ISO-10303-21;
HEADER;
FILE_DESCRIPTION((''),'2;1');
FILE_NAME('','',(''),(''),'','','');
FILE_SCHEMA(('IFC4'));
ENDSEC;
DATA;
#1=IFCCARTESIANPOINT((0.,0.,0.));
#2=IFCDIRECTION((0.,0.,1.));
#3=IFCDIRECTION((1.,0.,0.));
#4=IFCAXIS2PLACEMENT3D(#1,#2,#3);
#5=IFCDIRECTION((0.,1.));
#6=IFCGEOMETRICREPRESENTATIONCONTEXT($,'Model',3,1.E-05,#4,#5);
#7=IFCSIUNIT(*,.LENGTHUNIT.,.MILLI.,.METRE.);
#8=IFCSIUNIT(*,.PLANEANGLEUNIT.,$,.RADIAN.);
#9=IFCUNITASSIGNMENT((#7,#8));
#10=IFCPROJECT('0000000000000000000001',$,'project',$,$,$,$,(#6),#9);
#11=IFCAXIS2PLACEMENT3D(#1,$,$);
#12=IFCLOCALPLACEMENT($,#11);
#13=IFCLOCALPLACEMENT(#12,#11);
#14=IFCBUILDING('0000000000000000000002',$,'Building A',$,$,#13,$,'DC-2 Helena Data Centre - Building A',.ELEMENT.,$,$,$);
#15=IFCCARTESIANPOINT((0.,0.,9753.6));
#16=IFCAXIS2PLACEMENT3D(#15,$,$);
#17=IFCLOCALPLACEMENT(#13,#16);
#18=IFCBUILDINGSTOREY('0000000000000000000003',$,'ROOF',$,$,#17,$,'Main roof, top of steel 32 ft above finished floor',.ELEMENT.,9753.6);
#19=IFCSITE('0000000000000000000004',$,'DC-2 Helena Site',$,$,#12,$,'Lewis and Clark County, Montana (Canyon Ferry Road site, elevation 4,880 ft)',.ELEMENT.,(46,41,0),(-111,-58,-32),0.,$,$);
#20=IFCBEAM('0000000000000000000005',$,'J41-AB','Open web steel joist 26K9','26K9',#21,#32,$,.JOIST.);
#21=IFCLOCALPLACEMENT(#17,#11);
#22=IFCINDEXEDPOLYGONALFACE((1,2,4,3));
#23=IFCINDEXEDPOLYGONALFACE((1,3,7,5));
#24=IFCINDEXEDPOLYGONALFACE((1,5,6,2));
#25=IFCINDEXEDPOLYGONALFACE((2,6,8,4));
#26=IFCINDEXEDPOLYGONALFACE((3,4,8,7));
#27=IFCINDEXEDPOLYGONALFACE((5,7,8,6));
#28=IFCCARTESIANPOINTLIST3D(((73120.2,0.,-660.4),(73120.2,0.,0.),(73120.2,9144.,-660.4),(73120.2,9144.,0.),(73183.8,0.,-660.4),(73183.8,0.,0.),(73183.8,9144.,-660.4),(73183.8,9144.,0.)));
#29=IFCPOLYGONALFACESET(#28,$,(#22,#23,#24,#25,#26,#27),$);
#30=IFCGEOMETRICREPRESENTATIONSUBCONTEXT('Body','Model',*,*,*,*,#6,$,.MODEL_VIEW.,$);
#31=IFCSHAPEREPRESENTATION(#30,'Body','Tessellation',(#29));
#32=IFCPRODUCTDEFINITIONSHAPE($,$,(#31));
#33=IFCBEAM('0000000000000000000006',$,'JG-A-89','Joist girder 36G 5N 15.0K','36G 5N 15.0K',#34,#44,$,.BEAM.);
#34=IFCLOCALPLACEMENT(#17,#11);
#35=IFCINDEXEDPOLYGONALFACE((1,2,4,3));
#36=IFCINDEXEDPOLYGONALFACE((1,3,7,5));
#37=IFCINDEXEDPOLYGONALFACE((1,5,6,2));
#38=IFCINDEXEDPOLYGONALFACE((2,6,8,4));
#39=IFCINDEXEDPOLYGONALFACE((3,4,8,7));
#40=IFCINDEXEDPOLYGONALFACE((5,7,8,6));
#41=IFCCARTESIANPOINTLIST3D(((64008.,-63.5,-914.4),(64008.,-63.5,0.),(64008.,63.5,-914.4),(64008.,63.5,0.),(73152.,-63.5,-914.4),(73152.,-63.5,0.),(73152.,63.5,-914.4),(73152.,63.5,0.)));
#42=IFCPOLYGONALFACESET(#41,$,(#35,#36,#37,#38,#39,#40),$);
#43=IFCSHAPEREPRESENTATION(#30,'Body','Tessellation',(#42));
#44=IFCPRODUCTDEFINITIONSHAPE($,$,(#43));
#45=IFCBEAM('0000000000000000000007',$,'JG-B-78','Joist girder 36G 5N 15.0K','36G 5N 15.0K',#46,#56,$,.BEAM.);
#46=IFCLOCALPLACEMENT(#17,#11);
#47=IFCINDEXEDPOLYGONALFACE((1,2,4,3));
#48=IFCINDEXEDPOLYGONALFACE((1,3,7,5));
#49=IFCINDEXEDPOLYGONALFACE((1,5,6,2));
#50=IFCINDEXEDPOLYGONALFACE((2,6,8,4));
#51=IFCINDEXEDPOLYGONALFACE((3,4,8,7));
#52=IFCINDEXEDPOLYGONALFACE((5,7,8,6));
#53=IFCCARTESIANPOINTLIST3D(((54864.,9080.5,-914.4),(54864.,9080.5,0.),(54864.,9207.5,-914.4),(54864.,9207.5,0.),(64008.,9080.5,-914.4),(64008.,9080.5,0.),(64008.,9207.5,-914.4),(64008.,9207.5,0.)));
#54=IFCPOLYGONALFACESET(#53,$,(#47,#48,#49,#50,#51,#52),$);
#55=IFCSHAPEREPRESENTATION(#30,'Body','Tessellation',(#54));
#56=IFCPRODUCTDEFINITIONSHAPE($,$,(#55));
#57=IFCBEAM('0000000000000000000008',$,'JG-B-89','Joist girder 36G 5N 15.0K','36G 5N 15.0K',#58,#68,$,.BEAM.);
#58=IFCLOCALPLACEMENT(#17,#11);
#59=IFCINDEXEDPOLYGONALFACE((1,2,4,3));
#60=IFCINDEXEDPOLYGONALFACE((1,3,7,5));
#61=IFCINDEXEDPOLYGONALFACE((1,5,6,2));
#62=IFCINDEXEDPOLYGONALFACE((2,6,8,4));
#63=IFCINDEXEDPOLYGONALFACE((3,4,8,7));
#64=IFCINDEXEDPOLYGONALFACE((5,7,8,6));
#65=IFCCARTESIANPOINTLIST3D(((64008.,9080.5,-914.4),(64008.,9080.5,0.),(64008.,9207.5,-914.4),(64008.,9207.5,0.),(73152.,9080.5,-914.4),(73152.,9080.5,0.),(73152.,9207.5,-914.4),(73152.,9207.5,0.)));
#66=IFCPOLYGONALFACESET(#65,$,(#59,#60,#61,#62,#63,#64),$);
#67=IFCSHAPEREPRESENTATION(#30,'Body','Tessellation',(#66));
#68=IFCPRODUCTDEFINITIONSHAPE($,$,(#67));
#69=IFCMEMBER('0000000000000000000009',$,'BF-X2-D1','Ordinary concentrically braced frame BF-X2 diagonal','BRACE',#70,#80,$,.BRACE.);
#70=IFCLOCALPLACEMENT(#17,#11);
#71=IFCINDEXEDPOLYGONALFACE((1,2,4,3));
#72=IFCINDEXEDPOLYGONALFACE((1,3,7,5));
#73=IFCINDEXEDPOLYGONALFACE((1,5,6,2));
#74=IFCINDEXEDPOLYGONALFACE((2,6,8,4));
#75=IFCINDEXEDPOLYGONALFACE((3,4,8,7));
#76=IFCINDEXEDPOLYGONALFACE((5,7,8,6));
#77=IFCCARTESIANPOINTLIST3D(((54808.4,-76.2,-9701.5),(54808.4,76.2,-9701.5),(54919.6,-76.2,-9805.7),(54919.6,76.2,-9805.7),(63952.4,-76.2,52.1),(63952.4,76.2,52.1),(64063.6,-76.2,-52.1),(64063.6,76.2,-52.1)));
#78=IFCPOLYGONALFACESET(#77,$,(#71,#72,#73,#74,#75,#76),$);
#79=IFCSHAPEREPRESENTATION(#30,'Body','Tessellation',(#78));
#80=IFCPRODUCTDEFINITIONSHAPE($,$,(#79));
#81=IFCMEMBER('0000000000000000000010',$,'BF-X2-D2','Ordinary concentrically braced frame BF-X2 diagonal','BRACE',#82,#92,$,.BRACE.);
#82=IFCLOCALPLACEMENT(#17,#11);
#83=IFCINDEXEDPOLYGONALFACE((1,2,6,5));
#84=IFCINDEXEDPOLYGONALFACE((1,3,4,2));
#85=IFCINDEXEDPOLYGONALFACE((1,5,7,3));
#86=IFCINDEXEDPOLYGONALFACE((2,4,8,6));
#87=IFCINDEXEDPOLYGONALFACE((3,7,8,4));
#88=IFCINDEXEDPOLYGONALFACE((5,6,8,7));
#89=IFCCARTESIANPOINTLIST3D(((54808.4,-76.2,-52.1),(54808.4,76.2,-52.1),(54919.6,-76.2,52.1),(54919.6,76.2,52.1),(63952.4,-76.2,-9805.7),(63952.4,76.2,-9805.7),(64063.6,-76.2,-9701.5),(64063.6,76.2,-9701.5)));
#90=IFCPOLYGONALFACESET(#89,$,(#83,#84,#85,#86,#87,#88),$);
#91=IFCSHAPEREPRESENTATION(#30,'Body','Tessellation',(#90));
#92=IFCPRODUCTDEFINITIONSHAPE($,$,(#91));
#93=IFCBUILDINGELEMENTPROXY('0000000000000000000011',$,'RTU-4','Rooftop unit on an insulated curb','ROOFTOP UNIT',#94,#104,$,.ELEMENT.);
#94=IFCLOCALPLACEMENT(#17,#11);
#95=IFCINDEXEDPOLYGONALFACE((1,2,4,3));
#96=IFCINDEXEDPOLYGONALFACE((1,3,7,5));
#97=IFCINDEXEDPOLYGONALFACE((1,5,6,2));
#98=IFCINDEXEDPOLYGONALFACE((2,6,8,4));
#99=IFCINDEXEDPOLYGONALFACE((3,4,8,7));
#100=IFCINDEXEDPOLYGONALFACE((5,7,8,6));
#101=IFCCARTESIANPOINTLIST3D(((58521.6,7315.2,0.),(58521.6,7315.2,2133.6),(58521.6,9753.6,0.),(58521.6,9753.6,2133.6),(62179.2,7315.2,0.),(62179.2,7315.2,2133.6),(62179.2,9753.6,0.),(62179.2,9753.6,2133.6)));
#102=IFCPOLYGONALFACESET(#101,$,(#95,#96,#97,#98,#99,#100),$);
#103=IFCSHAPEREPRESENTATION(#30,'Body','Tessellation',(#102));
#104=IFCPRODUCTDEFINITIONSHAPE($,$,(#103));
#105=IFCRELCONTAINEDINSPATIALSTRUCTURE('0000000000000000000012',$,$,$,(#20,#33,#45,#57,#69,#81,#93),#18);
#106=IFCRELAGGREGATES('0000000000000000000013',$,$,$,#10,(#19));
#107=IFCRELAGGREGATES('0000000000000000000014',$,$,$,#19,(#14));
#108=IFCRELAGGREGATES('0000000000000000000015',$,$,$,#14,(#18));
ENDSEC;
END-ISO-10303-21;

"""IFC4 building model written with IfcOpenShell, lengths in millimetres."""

from ifc_helpers import new_model, si_unit, direction, frame, origin, origin_with_axes, origin_2d, place, context, subcontext, project, spatial, rectangle, extrude, element, save


model = new_model("IFC4")

# Units and contexts
model_context = context("Model", 3, precision=1e-05, world=origin_with_axes(), true_north=direction((0.0, 1.0)))
body_context = subcontext(model_context, "Body", "Model", "MODEL_VIEW")
ifc_project = project(units=[si_unit("LENGTHUNIT", "METRE", prefix="MILLI"), si_unit("PLANEANGLEUNIT", "RADIAN")], contexts=[model_context])

# Site, building, storey
site_placement = place(None, origin())
site = spatial("IfcSite", under=ifc_project, at=site_placement, Name="DC-2 Helena Site", LongName="Lewis and Clark County, Montana (Canyon Ferry Road site, elevation 4,880 ft)", CompositionType="ELEMENT", RefLatitude=(46, 41, 0), RefLongitude=(-111, -58, -32), RefElevation=0.0)
building_placement = place(site_placement, origin())
building = spatial("IfcBuilding", under=site, at=building_placement, Name="Building A", LongName="DC-2 Helena Data Centre - Building A", CompositionType="ELEMENT")
storey_placement = place(building_placement, frame((0.0, 0.0, 9753.6)))
storey = spatial("IfcBuildingStorey", under=building, at=storey_placement, Name="ROOF", LongName="Main roof, top of steel 32 ft above finished floor", CompositionType="ELEMENT", Elevation=9753.6)

# Shared definitions
placement_1 = place(storey_placement, frame((64008.0, 0.0, -9753.6)))

# Beams
placement_2 = place(storey_placement, frame((54864.0, 9144.0, 0.0)))
placement_3 = place(storey_placement, frame((64008.0, 0.0, 0.0)))
placement_4 = place(storey_placement, frame((64008.0, 9144.0, 0.0)))
for number, where, name in (
    (1, (73152.0, 0.0, 0.0), "J41-AB"),
):
    element("IfcBeam", number, at=place(storey_placement, frame(where)), inside=storey, Name=name, Description="Open web steel joist 26K9", ObjectType="26K9", PredefinedType="JOIST", context=body_context, shape_type="SweptSolid", body=[
        extrude(rectangle(XDim=63.5, YDim=660.4, at=origin_2d()), frame((0.0, 0.0, -330.2), z_axis=(0.0, 1.0, 0.0), x_axis=(1.0, 0.0, 0.0)), (0.0, 0.0, 1.0), 9144.0),
    ])
element("IfcBeam", 2, at=placement_3, inside=storey, Name="JG-A-89", Description="Joist girder 36G 5N 15.0K", ObjectType="36G 5N 15.0K", PredefinedType="BEAM", context=body_context, shape_type="SweptSolid", body=[
    extrude(rectangle(XDim=127.0, YDim=914.4, at=origin_2d()), frame((0.0, 0.0, -457.2), z_axis=(1.0, 0.0, 0.0), x_axis=(0.0, 1.0, 0.0)), (0.0, 0.0, 1.0), 9144.0),
])
element("IfcBeam", 3, at=placement_2, inside=storey, Name="JG-B-78", Description="Joist girder 36G 5N 15.0K", ObjectType="36G 5N 15.0K", PredefinedType="BEAM", context=body_context, shape_type="SweptSolid", body=[
    extrude(rectangle(XDim=127.0, YDim=914.4, at=origin_2d()), frame((0.0, 0.0, -457.2), z_axis=(1.0, 0.0, 0.0), x_axis=(0.0, 1.0, 0.0)), (0.0, 0.0, 1.0), 9144.0),
])
element("IfcBeam", 4, at=placement_4, inside=storey, Name="JG-B-89", Description="Joist girder 36G 5N 15.0K", ObjectType="36G 5N 15.0K", PredefinedType="BEAM", context=body_context, shape_type="SweptSolid", body=[
    extrude(rectangle(XDim=127.0, YDim=914.4, at=origin_2d()), frame((0.0, 0.0, -457.2), z_axis=(1.0, 0.0, 0.0), x_axis=(0.0, 1.0, 0.0)), (0.0, 0.0, 1.0), 9144.0),
])

# Members
member_1_placement = place(storey_placement, frame((54864.0, 0.0, -9753.6)))
element("IfcMember", 5, at=member_1_placement, inside=storey, Name="BF-X2-D1", Description="Ordinary concentrically braced frame BF-X2 diagonal", ObjectType="BRACE", PredefinedType="BRACE", context=body_context, shape_type="SweptSolid", body=[
    extrude(rectangle(XDim=152.4, YDim=152.4, at=origin_2d()), frame((0.0, 0.0, 0.0), z_axis=(0.683941, 0.0, 0.729537), x_axis=(0.0, 1.0, 0.0)), (0.0, 0.0, 1.0), 13369.6),
])
element("IfcMember", 6, at=placement_1, inside=storey, Name="BF-X2-D2", Description="Ordinary concentrically braced frame BF-X2 diagonal", ObjectType="BRACE", PredefinedType="BRACE", context=body_context, shape_type="SweptSolid", body=[
    extrude(rectangle(XDim=152.4, YDim=152.4, at=origin_2d()), frame((0.0, 0.0, 0.0), z_axis=(-0.683941, 0.0, 0.729537), x_axis=(0.0, 1.0, 0.0)), (0.0, 0.0, 1.0), 13369.6),
])

# Building element proxy
proxy_placement = place(storey_placement, frame((60350.4, 8534.4, 0.0)))
element("IfcBuildingElementProxy", 7, at=proxy_placement, inside=storey, Name="RTU-4", Description="Rooftop unit on an insulated curb", ObjectType="ROOFTOP UNIT", PredefinedType="ELEMENT", context=body_context, shape_type="SweptSolid", body=[
    extrude(rectangle(XDim=3657.6, YDim=2438.4, at=origin_2d()), origin(), (0.0, 0.0, 1.0), 2133.6),
])

save(model, "model.ifc")
